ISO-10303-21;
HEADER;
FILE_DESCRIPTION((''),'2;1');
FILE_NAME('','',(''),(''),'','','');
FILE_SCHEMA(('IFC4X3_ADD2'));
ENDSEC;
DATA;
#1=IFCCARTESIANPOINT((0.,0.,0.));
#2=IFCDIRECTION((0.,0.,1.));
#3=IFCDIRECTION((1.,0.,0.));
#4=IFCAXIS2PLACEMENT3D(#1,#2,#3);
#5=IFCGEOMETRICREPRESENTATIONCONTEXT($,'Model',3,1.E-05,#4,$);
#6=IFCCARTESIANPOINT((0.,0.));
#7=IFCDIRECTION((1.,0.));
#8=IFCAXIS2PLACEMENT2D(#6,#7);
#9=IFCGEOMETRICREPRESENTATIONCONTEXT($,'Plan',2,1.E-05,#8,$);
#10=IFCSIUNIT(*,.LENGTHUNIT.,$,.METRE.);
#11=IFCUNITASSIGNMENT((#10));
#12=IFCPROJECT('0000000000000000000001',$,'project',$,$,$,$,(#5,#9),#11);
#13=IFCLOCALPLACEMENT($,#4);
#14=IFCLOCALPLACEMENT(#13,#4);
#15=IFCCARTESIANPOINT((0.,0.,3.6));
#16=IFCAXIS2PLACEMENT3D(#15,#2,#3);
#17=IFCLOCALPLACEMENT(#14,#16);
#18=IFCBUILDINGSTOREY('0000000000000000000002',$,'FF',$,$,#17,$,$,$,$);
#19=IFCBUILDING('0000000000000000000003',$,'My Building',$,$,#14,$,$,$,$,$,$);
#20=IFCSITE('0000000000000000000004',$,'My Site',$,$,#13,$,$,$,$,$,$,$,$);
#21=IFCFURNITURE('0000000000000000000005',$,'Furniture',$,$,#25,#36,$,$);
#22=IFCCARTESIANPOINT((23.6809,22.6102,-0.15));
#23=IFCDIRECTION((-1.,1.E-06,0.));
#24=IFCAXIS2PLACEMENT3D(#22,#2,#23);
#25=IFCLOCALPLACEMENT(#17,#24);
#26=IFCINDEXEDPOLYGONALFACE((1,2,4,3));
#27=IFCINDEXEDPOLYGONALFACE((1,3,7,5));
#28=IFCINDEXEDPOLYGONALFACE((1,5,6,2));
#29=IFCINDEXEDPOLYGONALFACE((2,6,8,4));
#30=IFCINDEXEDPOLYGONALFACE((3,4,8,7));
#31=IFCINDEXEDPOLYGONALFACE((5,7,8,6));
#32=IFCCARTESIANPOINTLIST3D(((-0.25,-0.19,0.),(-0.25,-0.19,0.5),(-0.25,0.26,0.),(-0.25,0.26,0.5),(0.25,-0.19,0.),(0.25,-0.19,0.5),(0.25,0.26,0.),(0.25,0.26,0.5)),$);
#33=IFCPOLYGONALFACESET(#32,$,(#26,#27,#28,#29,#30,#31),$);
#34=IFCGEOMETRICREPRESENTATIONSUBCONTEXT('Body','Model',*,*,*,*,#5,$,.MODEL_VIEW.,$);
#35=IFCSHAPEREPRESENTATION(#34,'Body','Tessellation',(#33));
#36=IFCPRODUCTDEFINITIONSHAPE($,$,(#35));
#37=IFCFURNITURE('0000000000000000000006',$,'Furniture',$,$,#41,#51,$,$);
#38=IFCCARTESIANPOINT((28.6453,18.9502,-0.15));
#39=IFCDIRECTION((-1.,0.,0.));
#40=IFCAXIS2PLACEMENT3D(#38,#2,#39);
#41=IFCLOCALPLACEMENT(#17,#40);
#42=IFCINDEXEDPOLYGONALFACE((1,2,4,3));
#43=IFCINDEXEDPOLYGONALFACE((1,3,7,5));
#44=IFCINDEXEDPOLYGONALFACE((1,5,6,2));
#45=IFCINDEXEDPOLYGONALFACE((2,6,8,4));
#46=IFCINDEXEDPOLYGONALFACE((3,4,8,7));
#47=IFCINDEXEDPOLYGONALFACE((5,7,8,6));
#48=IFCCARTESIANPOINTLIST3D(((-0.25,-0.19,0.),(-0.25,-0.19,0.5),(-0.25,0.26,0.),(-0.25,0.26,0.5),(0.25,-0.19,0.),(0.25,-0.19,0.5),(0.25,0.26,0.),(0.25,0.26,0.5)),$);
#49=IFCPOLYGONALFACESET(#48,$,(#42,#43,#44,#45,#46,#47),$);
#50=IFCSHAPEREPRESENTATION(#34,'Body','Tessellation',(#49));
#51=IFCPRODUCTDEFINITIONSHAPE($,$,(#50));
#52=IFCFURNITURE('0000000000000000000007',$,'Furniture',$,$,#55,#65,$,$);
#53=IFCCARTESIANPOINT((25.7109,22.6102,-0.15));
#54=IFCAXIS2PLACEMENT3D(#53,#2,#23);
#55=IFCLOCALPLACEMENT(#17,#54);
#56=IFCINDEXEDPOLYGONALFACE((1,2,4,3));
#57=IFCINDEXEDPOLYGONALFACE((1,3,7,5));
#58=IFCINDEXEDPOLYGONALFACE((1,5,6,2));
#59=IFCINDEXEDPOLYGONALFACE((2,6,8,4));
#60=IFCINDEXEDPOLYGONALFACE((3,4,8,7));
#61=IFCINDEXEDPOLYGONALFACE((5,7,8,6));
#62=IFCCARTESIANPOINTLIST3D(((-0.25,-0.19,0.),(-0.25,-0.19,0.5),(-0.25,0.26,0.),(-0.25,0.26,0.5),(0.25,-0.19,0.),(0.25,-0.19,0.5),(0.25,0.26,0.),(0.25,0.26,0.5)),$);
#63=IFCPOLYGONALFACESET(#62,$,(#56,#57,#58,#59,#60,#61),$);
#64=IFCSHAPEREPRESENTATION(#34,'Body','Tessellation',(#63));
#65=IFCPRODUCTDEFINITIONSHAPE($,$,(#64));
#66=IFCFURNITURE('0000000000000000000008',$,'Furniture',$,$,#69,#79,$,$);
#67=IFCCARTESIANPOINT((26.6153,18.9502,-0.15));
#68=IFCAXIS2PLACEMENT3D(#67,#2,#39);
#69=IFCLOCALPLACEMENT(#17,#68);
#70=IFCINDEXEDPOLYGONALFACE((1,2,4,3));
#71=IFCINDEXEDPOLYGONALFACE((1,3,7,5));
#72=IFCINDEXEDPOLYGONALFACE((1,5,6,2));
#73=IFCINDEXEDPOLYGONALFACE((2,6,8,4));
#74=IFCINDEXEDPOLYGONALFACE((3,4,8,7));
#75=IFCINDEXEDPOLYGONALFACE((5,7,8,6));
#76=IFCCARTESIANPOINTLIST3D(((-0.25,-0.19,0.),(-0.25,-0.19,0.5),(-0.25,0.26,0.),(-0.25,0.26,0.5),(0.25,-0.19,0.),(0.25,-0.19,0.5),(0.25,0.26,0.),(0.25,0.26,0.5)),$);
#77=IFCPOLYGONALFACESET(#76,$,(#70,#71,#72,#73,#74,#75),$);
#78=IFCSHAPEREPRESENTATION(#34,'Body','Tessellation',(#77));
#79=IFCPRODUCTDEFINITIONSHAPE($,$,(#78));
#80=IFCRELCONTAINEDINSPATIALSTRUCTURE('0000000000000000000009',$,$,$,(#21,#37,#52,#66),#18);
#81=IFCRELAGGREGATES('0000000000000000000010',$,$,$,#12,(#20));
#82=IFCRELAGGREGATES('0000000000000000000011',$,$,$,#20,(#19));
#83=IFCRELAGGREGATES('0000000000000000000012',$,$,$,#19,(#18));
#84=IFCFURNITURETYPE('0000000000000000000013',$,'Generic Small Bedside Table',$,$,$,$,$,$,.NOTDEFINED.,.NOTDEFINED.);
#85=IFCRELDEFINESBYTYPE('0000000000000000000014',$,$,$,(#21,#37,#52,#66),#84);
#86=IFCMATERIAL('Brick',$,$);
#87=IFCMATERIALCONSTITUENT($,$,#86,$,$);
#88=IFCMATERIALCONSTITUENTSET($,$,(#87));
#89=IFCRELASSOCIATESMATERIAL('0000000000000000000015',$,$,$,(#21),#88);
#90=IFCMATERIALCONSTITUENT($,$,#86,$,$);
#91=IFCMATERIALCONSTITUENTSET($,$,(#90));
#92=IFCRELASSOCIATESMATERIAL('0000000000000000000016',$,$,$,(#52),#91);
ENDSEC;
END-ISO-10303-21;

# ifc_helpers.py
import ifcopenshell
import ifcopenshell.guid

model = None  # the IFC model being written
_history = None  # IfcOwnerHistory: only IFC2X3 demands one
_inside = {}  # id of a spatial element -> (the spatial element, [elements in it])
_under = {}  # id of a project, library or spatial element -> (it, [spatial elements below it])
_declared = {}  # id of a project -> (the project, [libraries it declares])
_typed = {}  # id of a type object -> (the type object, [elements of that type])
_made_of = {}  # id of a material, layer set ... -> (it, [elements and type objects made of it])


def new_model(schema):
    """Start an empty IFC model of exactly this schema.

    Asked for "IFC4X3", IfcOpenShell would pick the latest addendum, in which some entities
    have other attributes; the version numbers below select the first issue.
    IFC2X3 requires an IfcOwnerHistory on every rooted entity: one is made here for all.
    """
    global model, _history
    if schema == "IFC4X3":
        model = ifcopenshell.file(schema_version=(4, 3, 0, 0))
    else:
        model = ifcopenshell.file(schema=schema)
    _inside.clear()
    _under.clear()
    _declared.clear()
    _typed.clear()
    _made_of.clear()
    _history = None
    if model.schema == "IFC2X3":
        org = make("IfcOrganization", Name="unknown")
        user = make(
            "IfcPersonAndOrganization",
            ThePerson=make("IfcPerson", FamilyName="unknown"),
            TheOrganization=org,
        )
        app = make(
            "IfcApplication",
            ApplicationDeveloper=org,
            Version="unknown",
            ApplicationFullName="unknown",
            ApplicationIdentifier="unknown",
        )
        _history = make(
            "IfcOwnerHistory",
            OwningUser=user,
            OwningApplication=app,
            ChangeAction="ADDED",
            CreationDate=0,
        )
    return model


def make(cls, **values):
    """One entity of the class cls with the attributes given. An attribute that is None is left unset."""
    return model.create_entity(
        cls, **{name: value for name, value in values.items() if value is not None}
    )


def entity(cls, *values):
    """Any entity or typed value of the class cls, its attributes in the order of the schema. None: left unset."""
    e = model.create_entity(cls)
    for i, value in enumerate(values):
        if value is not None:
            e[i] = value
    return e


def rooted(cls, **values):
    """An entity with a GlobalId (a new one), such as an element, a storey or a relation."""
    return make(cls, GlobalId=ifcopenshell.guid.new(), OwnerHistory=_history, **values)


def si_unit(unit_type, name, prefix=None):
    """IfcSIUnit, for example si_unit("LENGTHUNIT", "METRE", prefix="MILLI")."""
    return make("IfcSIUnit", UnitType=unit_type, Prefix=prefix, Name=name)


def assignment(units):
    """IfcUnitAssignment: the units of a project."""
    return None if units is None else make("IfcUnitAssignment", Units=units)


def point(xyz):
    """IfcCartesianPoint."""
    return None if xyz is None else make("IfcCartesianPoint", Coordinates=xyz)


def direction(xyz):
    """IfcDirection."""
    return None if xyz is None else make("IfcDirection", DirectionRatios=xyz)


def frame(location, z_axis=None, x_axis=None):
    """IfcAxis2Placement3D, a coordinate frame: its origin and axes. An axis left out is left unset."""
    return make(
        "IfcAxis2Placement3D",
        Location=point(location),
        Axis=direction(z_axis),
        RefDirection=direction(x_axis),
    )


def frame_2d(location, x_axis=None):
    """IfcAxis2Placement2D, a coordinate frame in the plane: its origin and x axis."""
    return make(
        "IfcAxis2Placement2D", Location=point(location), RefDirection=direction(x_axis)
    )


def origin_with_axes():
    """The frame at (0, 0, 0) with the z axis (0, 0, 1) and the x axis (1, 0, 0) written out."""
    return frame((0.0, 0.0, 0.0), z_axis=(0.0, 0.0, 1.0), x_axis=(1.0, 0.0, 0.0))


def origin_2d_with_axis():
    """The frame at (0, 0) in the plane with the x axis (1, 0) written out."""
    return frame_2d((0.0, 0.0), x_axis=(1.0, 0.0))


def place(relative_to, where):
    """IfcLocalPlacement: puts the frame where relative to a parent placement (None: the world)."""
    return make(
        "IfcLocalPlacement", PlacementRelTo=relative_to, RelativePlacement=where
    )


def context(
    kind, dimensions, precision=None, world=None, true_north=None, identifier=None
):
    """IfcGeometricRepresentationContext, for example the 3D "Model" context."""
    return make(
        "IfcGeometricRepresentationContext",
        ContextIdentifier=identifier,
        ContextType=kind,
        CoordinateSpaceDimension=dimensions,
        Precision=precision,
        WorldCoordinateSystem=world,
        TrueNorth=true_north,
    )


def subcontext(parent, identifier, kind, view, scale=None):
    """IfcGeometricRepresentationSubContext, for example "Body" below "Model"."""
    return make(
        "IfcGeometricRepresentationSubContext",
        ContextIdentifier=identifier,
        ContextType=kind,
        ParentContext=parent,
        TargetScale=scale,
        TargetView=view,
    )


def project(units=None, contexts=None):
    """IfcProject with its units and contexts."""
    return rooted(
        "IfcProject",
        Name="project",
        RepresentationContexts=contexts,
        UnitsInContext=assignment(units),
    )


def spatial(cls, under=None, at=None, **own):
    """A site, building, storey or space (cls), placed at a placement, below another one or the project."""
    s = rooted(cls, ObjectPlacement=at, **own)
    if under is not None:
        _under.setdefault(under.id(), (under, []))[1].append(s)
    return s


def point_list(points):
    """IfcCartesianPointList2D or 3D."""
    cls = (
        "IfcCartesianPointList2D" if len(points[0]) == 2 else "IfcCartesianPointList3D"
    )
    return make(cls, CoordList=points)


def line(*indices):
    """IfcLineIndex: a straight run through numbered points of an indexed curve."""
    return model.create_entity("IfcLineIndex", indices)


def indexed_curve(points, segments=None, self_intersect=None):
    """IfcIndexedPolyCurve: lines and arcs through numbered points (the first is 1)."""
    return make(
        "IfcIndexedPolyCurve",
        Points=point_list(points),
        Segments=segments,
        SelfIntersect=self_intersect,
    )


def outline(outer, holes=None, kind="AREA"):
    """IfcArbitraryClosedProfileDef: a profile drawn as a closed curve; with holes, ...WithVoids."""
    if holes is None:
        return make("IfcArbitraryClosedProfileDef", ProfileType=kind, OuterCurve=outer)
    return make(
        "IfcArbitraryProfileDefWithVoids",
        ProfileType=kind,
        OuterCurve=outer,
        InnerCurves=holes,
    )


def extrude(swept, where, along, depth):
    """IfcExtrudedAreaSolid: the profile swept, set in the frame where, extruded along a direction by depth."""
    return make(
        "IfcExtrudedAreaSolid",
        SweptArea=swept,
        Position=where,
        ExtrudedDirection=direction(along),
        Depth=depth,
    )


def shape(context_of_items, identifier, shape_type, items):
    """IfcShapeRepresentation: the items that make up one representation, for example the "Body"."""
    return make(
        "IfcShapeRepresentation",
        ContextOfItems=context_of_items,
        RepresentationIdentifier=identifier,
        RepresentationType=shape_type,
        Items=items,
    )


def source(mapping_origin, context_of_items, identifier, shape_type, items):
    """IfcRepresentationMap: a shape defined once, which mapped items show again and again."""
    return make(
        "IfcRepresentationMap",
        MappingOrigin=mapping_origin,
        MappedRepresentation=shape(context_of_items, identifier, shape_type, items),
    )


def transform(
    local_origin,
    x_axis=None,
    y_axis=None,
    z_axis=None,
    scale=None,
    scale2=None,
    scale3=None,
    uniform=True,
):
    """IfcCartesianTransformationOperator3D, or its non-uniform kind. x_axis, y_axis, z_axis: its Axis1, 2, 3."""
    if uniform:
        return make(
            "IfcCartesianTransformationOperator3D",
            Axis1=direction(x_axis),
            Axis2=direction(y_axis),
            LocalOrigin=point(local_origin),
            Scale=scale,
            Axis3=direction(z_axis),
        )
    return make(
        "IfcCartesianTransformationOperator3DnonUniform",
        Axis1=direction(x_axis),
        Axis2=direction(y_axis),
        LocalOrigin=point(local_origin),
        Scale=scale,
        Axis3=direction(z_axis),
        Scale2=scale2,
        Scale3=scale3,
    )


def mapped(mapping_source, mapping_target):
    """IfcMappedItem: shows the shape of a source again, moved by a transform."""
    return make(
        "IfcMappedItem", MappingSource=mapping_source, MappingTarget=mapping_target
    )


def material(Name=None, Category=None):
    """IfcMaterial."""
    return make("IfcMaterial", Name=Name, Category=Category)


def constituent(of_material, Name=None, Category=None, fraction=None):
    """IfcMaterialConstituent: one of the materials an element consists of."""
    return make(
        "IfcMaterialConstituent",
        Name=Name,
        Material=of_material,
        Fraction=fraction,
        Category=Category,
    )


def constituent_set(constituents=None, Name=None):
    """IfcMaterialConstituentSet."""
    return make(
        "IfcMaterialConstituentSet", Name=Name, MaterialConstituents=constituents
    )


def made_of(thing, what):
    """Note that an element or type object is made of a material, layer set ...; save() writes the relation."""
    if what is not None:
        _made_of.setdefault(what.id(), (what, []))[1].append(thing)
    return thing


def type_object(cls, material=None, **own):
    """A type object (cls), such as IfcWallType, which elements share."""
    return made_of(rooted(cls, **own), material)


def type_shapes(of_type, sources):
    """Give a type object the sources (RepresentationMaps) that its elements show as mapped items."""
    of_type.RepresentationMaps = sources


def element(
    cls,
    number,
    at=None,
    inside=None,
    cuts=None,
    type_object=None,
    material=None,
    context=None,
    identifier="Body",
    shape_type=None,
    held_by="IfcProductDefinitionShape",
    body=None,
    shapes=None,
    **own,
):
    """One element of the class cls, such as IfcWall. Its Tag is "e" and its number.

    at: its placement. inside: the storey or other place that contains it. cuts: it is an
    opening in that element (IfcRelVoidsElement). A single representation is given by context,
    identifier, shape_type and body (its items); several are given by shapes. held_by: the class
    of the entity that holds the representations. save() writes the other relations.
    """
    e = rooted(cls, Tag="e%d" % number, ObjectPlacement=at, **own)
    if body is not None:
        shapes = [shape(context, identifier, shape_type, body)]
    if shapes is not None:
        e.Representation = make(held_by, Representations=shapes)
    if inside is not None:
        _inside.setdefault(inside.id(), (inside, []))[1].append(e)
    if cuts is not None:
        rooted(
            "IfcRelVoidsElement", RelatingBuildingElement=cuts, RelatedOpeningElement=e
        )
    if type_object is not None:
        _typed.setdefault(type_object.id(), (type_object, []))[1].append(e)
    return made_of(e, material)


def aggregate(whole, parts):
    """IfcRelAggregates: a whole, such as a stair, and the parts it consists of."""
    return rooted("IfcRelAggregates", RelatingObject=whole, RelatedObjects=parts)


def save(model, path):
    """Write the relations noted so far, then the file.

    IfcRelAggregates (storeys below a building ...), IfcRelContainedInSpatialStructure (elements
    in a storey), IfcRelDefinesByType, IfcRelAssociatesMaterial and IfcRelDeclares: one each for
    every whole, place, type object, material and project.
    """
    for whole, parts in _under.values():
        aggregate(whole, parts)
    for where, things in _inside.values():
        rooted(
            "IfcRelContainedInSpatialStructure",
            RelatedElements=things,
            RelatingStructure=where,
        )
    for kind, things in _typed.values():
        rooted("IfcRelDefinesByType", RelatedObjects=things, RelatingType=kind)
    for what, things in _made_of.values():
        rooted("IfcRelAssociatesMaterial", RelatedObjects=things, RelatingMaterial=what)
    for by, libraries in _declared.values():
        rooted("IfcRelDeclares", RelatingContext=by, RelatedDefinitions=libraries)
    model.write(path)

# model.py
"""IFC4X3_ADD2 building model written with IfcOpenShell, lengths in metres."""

from ifc_helpers import new_model, entity, si_unit, frame, origin_with_axes, origin_2d_with_axis, place, context, subcontext, project, spatial, line, indexed_curve, outline, extrude, shape, source, transform, mapped, material, constituent, constituent_set, type_object, type_shapes, element, save


model = new_model("IFC4X3_ADD2")

# Units and contexts
model_context = context("Model", 3, precision=1e-05, world=origin_with_axes())
plan_context = context("Plan", 2, precision=1e-05, world=origin_2d_with_axis())
body_context_1 = subcontext(model_context, "Body", "Model", "MODEL_VIEW")
body_context_2 = subcontext(plan_context, "Body", "Plan", "PLAN_VIEW")
ifc_project = project(units=[si_unit("LENGTHUNIT", "METRE")], contexts=[model_context, plan_context])

# Site, building, storey
site_placement = place(None, origin_with_axes())
site = spatial("IfcSite", under=ifc_project, at=site_placement, Name="My Site")
building_placement = place(site_placement, origin_with_axes())
building = spatial("IfcBuilding", under=site, at=building_placement, Name="My Building")
storey_placement = place(building_placement, frame((0.0, 0.0, 3.6), z_axis=(0.0, 0.0, 1.0), x_axis=(1.0, 0.0, 0.0)))
storey = spatial("IfcBuildingStorey", under=building, at=storey_placement, Name="FF")

# Shared definitions
ifc_material_1 = material(Name="Brick")

# Furniture
ifc_constituent_1 = constituent(ifc_material_1)
ifc_constituent_set_1 = constituent_set(constituents=[ifc_constituent_1])
furniture_type_1 = type_object("IfcFurnitureType", Name="Generic Small Bedside Table", AssemblyPlace="NOTDEFINED", PredefinedType="NOTDEFINED")
shared_shape_1 = source(origin_with_axes(), body_context_1, "Body", "SweptSolid", [
    extrude(outline(indexed_curve([(0.5, 0.45), (0.5, 0.0), (0.0, 0.0), (0.0, 0.45)], segments=[line(4, 1), line(1, 2), line(2, 3), line(3, 4)], self_intersect=False)), frame((-0.25, -0.19, 0.0), z_axis=(0.0, 0.0, 1.0), x_axis=(1.0, 0.0, 0.0)), (0.0, 0.0, 1.0), 0.5),
])
shared_shape_2 = source(origin_with_axes(), body_context_2, "Body", "Annotation2D", [
    entity("IfcGeometricCurveSet", [entity("IfcIndexedPolyCurve", entity("IfcCartesianPointList2D", [[-0.25, -0.19], [0.25, -0.19], [0.25, 0.26], [-0.25, 0.26]]), [entity("IfcLineIndex", [1, 2]), entity("IfcLineIndex", [2, 3]), entity("IfcLineIndex", [3, 4]), entity("IfcLineIndex", [4, 1])])]),
])
type_shapes(furniture_type_1, [shared_shape_1, shared_shape_2])
furniture_1_placement = place(storey_placement, frame((23.6809, 22.6102, -0.15), z_axis=(0.0, 0.0, 1.0), x_axis=(-1.0, 0.000001, 0.0)))
element("IfcFurniture", 1, at=furniture_1_placement, inside=storey, type_object=furniture_type_1, material=ifc_constituent_set_1, Name="Furniture", shapes=[
    shape(body_context_1, "Body", "MappedRepresentation", [mapped(shared_shape_1, transform((0.0, 0.0, 0.0), x_axis=(1.0, 0.0, 0.0), y_axis=(0.0, 1.0, 0.0), z_axis=(0.0, 0.0, 1.0), scale=1.0))]),
    shape(body_context_2, "Body", "MappedRepresentation", [mapped(shared_shape_2, transform((0.0, 0.0, 0.0), x_axis=(1.0, 0.0, 0.0), y_axis=(0.0, 1.0, 0.0), z_axis=(0.0, 0.0, 1.0), scale=1.0))]),
])
furniture_2_placement = place(storey_placement, frame((28.6453, 18.9502, -0.15), z_axis=(0.0, 0.0, 1.0), x_axis=(-1.0, 0.0, 0.0)))
element("IfcFurniture", 2, at=furniture_2_placement, inside=storey, type_object=furniture_type_1, Name="Furniture", shapes=[
    shape(body_context_1, "Body", "MappedRepresentation", [mapped(shared_shape_1, transform((0.0, 0.0, 0.0), x_axis=(1.0, 0.0, 0.0), y_axis=(0.0, 1.0, 0.0), z_axis=(0.0, 0.0, 1.0), scale=1.0))]),
    shape(body_context_2, "Body", "MappedRepresentation", [mapped(shared_shape_2, transform((0.0, 0.0, 0.0), x_axis=(1.0, 0.0, 0.0), y_axis=(0.0, 1.0, 0.0), z_axis=(0.0, 0.0, 1.0), scale=1.0))]),
])
ifc_constituent_2 = constituent(ifc_material_1)
ifc_constituent_set_2 = constituent_set(constituents=[ifc_constituent_2])
furniture_3_placement = place(storey_placement, frame((25.7109, 22.6102, -0.15), z_axis=(0.0, 0.0, 1.0), x_axis=(-1.0, 0.000001, 0.0)))
element("IfcFurniture", 3, at=furniture_3_placement, inside=storey, type_object=furniture_type_1, material=ifc_constituent_set_2, Name="Furniture", shapes=[
    shape(body_context_1, "Body", "MappedRepresentation", [mapped(shared_shape_1, transform((0.0, 0.0, 0.0), x_axis=(1.0, 0.0, 0.0), y_axis=(0.0, 1.0, 0.0), z_axis=(0.0, 0.0, 1.0), scale=1.0))]),
    shape(body_context_2, "Body", "MappedRepresentation", [mapped(shared_shape_2, transform((0.0, 0.0, 0.0), x_axis=(1.0, 0.0, 0.0), y_axis=(0.0, 1.0, 0.0), z_axis=(0.0, 0.0, 1.0), scale=1.0))]),
])
furniture_4_placement = place(storey_placement, frame((26.6153, 18.9502, -0.15), z_axis=(0.0, 0.0, 1.0), x_axis=(-1.0, 0.0, 0.0)))
element("IfcFurniture", 4, at=furniture_4_placement, inside=storey, type_object=furniture_type_1, Name="Furniture", shapes=[
    shape(body_context_1, "Body", "MappedRepresentation", [mapped(shared_shape_1, transform((0.0, 0.0, 0.0), x_axis=(1.0, 0.0, 0.0), y_axis=(0.0, 1.0, 0.0), z_axis=(0.0, 0.0, 1.0), scale=1.0))]),
    shape(body_context_2, "Body", "MappedRepresentation", [mapped(shared_shape_2, transform((0.0, 0.0, 0.0), x_axis=(1.0, 0.0, 0.0), y_axis=(0.0, 1.0, 0.0), z_axis=(0.0, 0.0, 1.0), scale=1.0))]),
])

save(model, "model.ifc")
